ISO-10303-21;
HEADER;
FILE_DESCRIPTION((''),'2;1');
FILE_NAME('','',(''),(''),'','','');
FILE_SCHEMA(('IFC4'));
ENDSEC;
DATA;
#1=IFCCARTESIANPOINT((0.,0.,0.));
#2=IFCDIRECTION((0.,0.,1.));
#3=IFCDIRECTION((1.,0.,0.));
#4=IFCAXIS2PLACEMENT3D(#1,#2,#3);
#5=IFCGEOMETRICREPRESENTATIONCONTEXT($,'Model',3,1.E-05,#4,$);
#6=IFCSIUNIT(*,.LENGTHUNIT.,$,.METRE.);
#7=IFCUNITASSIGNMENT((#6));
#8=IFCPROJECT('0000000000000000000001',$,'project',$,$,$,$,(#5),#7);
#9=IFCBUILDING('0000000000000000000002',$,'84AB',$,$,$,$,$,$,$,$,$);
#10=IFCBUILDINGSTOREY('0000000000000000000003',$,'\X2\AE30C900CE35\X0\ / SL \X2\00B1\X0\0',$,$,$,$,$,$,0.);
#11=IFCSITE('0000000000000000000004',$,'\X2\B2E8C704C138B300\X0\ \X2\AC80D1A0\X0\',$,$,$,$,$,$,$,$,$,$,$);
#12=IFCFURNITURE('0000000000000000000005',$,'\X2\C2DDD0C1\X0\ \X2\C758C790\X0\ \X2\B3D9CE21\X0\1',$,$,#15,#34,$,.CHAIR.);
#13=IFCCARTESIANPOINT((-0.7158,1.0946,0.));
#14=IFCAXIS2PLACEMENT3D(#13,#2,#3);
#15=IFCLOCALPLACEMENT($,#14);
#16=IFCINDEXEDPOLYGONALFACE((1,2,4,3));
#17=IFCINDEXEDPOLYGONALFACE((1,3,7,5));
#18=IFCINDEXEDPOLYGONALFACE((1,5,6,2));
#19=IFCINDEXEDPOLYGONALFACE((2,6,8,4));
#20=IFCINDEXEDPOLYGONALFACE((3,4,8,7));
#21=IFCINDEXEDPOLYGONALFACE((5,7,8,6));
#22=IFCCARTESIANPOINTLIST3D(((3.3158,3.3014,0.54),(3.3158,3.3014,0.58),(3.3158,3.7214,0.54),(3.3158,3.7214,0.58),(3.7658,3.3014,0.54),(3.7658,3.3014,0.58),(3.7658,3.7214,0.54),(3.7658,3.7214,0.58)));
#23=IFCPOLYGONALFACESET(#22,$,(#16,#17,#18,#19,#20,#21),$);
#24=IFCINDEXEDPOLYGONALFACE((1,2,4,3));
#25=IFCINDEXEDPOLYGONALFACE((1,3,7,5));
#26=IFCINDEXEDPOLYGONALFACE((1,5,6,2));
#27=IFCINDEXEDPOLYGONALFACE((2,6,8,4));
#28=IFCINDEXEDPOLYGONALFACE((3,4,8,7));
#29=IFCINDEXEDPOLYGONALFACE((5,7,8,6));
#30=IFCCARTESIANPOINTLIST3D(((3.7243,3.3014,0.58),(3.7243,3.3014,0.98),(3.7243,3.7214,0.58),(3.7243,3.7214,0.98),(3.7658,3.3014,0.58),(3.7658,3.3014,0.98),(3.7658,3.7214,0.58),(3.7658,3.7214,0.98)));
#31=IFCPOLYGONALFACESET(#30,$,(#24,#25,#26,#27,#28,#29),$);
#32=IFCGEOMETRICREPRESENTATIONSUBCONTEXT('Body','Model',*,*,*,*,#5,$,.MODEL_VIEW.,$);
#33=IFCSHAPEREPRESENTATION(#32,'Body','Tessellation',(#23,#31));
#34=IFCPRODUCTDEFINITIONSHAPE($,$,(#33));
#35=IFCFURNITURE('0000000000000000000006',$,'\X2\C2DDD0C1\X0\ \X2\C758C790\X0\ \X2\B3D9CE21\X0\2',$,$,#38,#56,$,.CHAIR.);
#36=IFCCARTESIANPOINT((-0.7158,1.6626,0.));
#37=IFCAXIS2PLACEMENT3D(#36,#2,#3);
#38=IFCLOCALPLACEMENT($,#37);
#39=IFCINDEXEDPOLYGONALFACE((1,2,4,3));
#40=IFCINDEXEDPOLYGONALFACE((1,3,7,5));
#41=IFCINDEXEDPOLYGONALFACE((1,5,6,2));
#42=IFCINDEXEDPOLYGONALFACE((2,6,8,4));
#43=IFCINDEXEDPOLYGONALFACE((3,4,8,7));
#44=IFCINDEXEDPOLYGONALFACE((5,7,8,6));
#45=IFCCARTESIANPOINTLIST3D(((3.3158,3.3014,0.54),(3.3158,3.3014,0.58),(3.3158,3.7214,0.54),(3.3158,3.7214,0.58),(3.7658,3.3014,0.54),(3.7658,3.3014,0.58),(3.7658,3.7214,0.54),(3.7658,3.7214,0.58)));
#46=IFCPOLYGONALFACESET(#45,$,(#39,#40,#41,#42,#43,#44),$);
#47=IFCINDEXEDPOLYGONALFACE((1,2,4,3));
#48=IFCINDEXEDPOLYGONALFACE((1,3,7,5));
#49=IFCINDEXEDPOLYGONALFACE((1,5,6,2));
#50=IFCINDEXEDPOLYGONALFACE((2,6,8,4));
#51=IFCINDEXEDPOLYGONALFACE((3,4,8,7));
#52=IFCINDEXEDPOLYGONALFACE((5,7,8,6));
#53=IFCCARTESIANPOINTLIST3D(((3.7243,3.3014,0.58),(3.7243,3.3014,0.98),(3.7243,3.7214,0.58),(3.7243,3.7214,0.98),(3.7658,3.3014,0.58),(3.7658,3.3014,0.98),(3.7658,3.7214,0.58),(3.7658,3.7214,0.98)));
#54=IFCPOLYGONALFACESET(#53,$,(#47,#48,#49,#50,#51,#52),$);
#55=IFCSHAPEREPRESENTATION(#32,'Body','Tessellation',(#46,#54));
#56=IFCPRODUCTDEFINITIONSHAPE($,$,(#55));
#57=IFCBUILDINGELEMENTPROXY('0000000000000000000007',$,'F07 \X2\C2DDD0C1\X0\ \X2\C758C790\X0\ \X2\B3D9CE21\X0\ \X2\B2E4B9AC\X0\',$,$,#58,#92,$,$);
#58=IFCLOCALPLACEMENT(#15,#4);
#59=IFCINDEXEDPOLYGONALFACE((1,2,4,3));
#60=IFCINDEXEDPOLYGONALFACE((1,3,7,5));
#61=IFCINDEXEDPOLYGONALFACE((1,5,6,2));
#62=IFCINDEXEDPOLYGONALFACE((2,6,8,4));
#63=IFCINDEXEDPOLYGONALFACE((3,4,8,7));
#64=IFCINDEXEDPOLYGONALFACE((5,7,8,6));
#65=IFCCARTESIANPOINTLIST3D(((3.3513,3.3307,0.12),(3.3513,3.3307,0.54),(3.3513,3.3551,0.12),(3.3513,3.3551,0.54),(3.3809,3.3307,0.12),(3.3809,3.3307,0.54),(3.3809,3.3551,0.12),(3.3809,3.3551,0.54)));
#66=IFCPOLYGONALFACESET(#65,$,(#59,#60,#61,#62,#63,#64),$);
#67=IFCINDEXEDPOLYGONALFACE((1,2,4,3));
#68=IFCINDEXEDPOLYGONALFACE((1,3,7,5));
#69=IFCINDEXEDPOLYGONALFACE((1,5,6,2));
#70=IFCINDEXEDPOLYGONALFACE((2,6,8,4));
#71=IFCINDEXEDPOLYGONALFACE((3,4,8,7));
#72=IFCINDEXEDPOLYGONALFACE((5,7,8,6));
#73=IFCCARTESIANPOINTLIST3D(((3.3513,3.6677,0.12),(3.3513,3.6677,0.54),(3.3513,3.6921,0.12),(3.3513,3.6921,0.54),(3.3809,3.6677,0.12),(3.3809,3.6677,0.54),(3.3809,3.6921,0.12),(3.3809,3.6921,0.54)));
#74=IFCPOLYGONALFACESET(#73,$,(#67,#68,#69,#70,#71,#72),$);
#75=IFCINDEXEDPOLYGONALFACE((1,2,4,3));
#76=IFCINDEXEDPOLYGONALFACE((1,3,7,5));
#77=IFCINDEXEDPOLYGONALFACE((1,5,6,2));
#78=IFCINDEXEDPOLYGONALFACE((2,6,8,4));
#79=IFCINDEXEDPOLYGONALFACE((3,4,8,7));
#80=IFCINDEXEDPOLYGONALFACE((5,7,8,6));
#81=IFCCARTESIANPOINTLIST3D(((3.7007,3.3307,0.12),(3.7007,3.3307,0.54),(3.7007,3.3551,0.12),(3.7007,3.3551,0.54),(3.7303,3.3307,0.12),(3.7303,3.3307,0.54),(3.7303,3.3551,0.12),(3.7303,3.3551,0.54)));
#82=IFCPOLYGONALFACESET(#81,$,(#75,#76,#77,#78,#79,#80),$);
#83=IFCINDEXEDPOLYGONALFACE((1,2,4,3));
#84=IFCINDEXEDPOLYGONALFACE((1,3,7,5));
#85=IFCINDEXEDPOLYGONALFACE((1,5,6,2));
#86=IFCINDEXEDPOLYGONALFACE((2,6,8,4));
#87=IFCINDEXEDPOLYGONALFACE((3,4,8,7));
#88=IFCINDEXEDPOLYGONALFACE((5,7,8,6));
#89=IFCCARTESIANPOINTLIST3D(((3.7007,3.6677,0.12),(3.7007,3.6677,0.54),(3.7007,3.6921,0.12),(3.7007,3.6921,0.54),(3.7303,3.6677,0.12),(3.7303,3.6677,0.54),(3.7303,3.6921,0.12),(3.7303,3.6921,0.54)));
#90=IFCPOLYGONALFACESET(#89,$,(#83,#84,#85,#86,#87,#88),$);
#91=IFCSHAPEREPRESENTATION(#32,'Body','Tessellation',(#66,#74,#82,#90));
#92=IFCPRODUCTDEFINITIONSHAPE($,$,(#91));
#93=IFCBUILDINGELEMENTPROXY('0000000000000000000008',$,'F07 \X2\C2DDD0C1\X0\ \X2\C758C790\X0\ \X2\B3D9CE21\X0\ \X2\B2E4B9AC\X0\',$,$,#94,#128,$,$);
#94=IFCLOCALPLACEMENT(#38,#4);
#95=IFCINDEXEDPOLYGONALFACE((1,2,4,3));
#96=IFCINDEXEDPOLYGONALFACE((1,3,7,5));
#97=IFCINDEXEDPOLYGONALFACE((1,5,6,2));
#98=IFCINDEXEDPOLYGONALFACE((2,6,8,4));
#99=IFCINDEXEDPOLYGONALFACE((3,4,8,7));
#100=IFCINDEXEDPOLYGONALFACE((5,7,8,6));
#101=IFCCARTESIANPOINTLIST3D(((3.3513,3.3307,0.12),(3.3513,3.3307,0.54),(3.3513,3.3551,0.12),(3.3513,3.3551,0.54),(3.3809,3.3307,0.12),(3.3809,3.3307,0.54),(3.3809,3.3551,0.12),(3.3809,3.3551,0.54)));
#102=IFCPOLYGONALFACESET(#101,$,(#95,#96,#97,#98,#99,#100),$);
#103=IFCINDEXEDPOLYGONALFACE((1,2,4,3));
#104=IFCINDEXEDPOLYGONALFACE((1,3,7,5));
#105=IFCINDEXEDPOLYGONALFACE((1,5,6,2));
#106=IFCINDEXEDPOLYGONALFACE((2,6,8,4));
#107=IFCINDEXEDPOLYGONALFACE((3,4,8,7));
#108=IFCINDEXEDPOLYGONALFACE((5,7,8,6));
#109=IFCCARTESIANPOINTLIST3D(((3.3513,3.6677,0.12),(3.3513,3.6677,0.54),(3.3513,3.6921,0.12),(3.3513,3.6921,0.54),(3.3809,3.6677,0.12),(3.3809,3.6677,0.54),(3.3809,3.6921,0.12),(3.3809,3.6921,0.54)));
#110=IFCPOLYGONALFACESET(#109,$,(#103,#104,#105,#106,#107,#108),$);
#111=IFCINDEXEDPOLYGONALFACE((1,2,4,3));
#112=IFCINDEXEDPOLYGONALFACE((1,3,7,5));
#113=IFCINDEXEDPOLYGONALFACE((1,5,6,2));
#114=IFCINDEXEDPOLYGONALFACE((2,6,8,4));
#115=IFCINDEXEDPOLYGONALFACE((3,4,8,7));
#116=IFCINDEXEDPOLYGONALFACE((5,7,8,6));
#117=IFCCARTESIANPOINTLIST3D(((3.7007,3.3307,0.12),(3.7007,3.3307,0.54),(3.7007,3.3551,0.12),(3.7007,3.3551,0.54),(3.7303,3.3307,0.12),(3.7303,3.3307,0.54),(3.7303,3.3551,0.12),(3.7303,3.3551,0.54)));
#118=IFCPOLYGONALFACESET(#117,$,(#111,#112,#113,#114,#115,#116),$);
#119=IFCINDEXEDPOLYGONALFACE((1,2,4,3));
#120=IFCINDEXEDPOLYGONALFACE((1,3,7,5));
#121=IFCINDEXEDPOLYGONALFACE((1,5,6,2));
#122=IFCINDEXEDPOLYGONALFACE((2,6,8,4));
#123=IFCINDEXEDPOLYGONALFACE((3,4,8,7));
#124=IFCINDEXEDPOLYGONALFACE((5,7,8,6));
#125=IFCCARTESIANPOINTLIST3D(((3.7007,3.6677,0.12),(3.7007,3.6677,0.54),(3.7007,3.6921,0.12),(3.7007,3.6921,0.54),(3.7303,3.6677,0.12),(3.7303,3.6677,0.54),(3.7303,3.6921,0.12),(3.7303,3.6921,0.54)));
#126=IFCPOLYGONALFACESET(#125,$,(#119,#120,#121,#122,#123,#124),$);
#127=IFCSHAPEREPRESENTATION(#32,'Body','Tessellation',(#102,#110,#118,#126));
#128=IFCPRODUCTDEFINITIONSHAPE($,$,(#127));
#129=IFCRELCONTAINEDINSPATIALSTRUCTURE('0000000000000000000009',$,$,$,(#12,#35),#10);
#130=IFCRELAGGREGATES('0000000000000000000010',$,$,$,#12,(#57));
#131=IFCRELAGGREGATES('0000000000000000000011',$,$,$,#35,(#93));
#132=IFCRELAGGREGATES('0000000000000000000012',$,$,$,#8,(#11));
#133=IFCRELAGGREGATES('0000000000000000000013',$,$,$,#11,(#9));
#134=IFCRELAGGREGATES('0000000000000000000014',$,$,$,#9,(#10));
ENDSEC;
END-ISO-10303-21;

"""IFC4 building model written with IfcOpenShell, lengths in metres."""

from ifc_helpers import new_model, si_unit, frame, origin_with_axes, place, context, subcontext, project, spatial, polyline, outline, extrude, element, aggregate, save


model = new_model("IFC4")

# Units and contexts
model_context = context("Model", 3, precision=1e-05, world=origin_with_axes())
body_context = subcontext(model_context, "Body", "Model", "MODEL_VIEW")
ifc_project = project(units=[si_unit("LENGTHUNIT", "METRE")], contexts=[model_context])

# Site, building, storey
site = spatial("IfcSite", under=ifc_project, Name="단위세대 검토")
building = spatial("IfcBuilding", under=site, Name="84AB")
storey = spatial("IfcBuildingStorey", under=building, Name="기준층 / SL ±0", Elevation=0.0)

# Furniture
furniture_1_placement = place(None, frame((-0.7158, 1.0946, 0.0), z_axis=(0.0, 0.0, 1.0), x_axis=(1.0, 0.0, 0.0)))
furniture_1 = element("IfcFurniture", 1, at=furniture_1_placement, inside=storey, Name="식탁 의자 동측1", PredefinedType="CHAIR", context=body_context, shape_type="SweptSolid", body=[
    extrude(outline(polyline([(3.7658, 3.3014), (3.7658, 3.7214), (3.3158, 3.7214), (3.3158, 3.3014), (3.7658, 3.3014)])), frame((0.0, 0.0, 0.54)), (0.0, 0.0, 1.0), 0.04),
    extrude(outline(polyline([(3.7658, 3.3014), (3.7658, 3.7214), (3.7243, 3.7214), (3.7243, 3.3014), (3.7658, 3.3014)])), frame((0.0, 0.0, 0.58)), (0.0, 0.0, 1.0), 0.4),
])
furniture_2_placement = place(None, frame((-0.7158, 1.6626, 0.0), z_axis=(0.0, 0.0, 1.0), x_axis=(1.0, 0.0, 0.0)))
furniture_2 = element("IfcFurniture", 2, at=furniture_2_placement, inside=storey, Name="식탁 의자 동측2", PredefinedType="CHAIR", context=body_context, shape_type="SweptSolid", body=[
    extrude(outline(polyline([(3.7658, 3.3014), (3.7658, 3.7214), (3.3158, 3.7214), (3.3158, 3.3014), (3.7658, 3.3014)])), frame((0.0, 0.0, 0.54)), (0.0, 0.0, 1.0), 0.04),
    extrude(outline(polyline([(3.7658, 3.3014), (3.7658, 3.7214), (3.7243, 3.7214), (3.7243, 3.3014), (3.7658, 3.3014)])), frame((0.0, 0.0, 0.58)), (0.0, 0.0, 1.0), 0.4),
])

# Building element proxies
proxy_1_placement = place(furniture_1_placement, origin_with_axes())
proxy_1 = element("IfcBuildingElementProxy", 3, at=proxy_1_placement, Name="F07 식탁 의자 동측 다리", context=body_context, shape_type="SweptSolid", body=[
    extrude(outline(polyline([(3.3809, 3.3307), (3.3809, 3.3551), (3.3513, 3.3551), (3.3513, 3.3307), (3.3809, 3.3307)])), frame((0.0, 0.0, 0.12)), (0.0, 0.0, 1.0), 0.42),
    extrude(outline(polyline([(3.3809, 3.6677), (3.3809, 3.6921), (3.3513, 3.6921), (3.3513, 3.6677), (3.3809, 3.6677)])), frame((0.0, 0.0, 0.12)), (0.0, 0.0, 1.0), 0.42),
    extrude(outline(polyline([(3.7303, 3.3307), (3.7303, 3.3551), (3.7007, 3.3551), (3.7007, 3.3307), (3.7303, 3.3307)])), frame((0.0, 0.0, 0.12)), (0.0, 0.0, 1.0), 0.42),
    extrude(outline(polyline([(3.7303, 3.6677), (3.7303, 3.6921), (3.7007, 3.6921), (3.7007, 3.6677), (3.7303, 3.6677)])), frame((0.0, 0.0, 0.12)), (0.0, 0.0, 1.0), 0.42),
])
aggregate(furniture_1, [proxy_1])
proxy_2_placement = place(furniture_2_placement, origin_with_axes())
proxy_2 = element("IfcBuildingElementProxy", 4, at=proxy_2_placement, Name="F07 식탁 의자 동측 다리", context=body_context, shape_type="SweptSolid", body=[
    extrude(outline(polyline([(3.3809, 3.3307), (3.3809, 3.3551), (3.3513, 3.3551), (3.3513, 3.3307), (3.3809, 3.3307)])), frame((0.0, 0.0, 0.12)), (0.0, 0.0, 1.0), 0.42),
    extrude(outline(polyline([(3.3809, 3.6677), (3.3809, 3.6921), (3.3513, 3.6921), (3.3513, 3.6677), (3.3809, 3.6677)])), frame((0.0, 0.0, 0.12)), (0.0, 0.0, 1.0), 0.42),
    extrude(outline(polyline([(3.7303, 3.3307), (3.7303, 3.3551), (3.7007, 3.3551), (3.7007, 3.3307), (3.7303, 3.3307)])), frame((0.0, 0.0, 0.12)), (0.0, 0.0, 1.0), 0.42),
    extrude(outline(polyline([(3.7303, 3.6677), (3.7303, 3.6921), (3.7007, 3.6921), (3.7007, 3.6677), (3.7303, 3.6677)])), frame((0.0, 0.0, 0.12)), (0.0, 0.0, 1.0), 0.42),
])
aggregate(furniture_2, [proxy_2])

save(model, "model.ifc")
